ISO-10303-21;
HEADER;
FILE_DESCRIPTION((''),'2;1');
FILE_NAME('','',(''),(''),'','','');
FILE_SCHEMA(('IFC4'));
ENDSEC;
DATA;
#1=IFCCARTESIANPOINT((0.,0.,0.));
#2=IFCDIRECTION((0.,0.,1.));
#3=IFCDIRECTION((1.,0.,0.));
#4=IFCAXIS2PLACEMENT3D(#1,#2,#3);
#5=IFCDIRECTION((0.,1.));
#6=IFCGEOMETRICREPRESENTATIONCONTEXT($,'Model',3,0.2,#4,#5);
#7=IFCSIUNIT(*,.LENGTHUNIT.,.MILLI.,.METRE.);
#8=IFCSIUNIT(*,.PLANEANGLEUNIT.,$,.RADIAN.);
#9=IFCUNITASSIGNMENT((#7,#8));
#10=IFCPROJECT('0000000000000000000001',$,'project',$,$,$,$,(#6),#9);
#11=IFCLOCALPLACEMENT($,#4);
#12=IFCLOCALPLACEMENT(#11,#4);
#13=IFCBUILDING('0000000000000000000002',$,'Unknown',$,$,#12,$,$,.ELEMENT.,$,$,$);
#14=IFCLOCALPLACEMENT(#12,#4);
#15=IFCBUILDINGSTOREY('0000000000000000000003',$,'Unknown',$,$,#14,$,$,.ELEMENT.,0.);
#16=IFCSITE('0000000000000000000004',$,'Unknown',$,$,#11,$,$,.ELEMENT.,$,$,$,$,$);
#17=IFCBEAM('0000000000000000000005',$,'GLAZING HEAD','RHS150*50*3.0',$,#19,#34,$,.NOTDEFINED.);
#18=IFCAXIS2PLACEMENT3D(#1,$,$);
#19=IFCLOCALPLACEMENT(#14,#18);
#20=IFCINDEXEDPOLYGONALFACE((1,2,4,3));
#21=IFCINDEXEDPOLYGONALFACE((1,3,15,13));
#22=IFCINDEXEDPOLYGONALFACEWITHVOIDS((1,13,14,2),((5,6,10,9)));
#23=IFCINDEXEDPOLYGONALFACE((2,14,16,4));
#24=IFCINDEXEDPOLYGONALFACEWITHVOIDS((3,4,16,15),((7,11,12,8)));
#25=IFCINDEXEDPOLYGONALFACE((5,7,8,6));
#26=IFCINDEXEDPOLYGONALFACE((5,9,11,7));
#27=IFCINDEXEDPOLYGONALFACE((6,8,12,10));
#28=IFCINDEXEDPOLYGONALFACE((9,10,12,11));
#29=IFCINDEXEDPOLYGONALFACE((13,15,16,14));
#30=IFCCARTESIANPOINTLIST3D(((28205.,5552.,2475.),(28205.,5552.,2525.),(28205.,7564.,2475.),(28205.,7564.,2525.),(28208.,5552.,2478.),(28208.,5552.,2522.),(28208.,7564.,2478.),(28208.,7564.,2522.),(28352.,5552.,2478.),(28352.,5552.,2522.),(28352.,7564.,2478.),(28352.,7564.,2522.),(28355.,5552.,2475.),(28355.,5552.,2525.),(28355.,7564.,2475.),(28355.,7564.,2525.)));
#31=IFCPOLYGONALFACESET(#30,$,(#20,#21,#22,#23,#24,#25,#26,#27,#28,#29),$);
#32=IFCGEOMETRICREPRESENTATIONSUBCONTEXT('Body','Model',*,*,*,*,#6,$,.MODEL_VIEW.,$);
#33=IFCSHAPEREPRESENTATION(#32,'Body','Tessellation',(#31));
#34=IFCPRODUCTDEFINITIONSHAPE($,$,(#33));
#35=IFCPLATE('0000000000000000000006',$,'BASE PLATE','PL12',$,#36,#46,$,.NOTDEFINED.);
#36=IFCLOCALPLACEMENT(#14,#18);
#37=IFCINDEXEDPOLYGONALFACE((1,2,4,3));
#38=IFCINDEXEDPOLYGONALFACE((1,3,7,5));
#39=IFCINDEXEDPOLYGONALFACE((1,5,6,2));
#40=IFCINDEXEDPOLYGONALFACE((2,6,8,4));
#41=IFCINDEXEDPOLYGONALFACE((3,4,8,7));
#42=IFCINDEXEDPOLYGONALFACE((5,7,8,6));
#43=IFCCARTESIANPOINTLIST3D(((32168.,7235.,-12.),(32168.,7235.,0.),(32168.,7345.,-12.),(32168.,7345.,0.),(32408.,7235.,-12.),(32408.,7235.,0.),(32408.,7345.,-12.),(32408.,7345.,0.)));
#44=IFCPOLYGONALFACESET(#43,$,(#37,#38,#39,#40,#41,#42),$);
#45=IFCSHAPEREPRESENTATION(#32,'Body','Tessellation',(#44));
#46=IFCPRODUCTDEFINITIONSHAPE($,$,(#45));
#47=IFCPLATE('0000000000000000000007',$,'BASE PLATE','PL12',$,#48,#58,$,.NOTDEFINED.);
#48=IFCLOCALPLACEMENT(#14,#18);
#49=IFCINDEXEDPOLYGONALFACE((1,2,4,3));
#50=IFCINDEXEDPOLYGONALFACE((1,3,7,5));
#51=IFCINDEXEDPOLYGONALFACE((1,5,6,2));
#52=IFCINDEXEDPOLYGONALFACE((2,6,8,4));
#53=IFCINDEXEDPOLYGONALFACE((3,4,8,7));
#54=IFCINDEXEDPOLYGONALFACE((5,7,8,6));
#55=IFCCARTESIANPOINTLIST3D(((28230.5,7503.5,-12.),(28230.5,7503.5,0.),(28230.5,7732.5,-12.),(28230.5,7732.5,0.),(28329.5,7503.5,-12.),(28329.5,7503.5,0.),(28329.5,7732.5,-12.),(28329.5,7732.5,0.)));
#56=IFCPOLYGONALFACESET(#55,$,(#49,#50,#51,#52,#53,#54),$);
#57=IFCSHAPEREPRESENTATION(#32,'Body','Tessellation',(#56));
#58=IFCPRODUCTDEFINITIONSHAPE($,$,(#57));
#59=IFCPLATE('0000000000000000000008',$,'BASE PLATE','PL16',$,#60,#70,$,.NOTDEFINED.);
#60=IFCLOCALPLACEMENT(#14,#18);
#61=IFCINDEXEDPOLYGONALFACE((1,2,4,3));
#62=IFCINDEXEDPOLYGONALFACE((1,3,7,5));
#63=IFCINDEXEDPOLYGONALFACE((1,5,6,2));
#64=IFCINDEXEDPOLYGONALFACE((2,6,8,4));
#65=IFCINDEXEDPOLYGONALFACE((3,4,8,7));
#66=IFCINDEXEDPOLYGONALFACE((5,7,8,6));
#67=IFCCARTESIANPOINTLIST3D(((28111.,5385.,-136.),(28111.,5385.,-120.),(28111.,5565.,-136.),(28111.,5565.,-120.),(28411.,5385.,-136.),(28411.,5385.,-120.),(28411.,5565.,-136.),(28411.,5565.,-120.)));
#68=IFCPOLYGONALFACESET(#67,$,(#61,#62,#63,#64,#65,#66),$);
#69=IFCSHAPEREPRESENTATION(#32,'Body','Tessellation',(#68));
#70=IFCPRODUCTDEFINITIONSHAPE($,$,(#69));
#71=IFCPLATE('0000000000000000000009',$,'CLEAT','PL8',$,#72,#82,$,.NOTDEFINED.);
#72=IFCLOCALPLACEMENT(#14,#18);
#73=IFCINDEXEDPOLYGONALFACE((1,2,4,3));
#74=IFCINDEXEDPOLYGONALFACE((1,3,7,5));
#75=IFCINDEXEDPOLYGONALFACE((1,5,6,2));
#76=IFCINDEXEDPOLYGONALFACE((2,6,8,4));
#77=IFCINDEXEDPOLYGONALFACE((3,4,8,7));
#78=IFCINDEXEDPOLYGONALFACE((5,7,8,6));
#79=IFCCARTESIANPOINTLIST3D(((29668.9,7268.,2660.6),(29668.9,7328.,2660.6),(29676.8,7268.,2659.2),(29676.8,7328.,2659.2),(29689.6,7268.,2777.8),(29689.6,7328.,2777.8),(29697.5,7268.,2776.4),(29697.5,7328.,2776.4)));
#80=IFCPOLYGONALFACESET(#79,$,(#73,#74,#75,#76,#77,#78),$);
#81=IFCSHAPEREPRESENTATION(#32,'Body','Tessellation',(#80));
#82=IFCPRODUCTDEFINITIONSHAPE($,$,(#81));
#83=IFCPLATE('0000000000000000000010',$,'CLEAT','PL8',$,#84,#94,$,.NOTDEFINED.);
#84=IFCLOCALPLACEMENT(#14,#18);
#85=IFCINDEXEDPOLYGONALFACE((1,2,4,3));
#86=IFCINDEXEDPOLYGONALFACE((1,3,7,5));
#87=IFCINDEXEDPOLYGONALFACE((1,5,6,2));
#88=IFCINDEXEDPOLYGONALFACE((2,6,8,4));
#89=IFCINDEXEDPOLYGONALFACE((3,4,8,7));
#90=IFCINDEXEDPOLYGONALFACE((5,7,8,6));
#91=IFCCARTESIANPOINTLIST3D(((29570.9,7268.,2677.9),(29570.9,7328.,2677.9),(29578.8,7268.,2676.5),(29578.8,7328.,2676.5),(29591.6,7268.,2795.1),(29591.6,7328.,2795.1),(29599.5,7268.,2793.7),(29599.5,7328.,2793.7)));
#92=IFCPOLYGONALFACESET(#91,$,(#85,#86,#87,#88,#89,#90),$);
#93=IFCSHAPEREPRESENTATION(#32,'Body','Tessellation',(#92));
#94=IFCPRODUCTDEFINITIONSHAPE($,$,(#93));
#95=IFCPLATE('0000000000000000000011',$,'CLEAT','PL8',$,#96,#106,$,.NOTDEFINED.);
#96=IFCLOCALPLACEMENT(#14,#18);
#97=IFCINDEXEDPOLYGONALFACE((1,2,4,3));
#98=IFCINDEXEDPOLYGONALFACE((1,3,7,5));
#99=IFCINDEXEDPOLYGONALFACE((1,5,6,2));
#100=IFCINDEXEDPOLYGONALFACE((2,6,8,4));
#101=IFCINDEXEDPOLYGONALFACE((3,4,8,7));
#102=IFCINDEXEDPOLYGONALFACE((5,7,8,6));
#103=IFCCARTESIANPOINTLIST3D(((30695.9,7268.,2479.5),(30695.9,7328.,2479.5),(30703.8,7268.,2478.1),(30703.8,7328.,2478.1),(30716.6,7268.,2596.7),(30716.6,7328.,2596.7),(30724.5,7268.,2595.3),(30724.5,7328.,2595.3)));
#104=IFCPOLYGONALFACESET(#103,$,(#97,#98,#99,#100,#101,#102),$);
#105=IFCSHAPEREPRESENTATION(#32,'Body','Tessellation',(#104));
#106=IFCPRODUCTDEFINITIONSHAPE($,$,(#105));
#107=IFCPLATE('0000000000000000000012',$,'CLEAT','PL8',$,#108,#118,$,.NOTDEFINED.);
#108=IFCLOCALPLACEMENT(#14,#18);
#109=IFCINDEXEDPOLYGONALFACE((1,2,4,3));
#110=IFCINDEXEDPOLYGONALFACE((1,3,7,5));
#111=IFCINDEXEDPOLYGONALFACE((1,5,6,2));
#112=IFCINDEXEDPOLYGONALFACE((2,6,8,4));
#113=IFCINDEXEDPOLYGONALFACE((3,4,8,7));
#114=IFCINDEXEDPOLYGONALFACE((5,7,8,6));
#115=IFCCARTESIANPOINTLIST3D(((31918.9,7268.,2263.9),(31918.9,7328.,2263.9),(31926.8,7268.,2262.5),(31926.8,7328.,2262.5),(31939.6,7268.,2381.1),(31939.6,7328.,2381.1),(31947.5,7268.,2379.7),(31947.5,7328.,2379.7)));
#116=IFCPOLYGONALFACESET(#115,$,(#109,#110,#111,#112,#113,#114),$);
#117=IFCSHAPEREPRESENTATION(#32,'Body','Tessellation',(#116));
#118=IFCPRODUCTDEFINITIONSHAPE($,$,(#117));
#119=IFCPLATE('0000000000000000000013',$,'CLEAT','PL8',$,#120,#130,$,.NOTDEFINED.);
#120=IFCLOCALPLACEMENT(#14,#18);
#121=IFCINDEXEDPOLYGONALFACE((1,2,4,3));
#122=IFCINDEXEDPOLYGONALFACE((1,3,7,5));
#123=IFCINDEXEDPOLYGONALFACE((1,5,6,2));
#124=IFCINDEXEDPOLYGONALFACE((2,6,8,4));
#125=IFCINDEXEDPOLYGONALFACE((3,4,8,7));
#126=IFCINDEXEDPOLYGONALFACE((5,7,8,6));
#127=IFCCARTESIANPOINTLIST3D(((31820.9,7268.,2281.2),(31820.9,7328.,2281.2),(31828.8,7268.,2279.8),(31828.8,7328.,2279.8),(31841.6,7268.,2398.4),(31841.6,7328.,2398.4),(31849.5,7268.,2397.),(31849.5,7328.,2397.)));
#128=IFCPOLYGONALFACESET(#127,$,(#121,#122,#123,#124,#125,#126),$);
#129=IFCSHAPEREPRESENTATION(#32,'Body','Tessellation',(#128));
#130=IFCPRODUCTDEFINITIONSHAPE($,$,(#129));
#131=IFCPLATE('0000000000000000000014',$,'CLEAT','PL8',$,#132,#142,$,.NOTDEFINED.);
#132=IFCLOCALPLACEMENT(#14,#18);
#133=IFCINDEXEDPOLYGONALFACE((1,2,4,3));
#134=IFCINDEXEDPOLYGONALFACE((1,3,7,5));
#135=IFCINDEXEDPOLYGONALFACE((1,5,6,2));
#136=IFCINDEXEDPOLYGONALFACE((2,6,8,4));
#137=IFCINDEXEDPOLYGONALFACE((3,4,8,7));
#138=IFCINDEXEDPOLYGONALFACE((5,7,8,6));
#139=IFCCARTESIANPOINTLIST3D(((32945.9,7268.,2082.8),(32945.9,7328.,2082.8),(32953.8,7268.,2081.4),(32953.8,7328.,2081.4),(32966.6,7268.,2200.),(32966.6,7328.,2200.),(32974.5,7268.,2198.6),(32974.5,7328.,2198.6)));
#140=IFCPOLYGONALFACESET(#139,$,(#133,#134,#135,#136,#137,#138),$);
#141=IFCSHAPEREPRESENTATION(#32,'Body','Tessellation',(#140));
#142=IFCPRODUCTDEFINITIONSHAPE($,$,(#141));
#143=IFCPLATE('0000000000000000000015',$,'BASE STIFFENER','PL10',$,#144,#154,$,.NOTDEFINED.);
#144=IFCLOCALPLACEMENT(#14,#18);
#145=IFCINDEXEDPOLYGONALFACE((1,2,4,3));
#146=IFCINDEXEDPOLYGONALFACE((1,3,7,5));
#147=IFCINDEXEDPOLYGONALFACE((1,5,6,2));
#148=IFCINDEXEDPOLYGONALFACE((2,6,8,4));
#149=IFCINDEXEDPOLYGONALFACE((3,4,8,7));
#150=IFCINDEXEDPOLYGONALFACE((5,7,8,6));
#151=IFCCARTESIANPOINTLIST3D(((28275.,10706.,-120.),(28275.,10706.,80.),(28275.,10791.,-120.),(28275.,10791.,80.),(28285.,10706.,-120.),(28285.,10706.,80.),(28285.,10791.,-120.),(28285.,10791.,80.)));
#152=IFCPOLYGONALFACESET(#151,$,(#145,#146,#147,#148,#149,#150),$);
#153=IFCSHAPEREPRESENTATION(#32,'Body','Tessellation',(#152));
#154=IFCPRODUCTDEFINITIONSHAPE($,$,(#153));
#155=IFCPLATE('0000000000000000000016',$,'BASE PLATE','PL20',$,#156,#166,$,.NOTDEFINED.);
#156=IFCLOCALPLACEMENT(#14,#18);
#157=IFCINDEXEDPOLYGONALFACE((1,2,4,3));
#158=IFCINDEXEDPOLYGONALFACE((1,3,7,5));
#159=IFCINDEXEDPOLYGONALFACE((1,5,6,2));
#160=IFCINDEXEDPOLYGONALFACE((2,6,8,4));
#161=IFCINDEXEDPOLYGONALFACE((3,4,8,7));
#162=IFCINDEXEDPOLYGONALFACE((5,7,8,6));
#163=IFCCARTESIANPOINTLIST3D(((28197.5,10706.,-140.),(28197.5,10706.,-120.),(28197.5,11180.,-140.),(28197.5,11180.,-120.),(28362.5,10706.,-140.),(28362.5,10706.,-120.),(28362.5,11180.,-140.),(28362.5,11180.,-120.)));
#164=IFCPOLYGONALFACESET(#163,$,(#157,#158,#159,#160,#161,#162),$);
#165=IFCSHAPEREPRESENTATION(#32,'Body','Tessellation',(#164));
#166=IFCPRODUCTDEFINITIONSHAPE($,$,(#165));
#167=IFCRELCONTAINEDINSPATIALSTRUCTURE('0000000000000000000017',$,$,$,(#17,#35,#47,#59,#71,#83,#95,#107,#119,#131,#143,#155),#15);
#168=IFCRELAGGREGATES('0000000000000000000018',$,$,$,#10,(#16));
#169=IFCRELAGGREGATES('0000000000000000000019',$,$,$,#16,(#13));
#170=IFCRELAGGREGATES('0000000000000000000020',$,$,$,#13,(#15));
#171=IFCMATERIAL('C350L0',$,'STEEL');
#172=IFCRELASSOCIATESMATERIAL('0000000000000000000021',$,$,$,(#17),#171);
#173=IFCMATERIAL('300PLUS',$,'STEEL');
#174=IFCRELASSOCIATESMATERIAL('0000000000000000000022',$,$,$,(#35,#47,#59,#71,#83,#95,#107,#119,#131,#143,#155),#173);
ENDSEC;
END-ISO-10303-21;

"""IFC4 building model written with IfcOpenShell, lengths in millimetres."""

from ifc_helpers import new_model, si_unit, direction, frame, origin_with_axes, place, context, subcontext, project, spatial, line, indexed_curve, outline, extrude, material, element, save


model = new_model("IFC4")

# Units and contexts
model_context = context("Model", 3, precision=0.2, world=origin_with_axes(), true_north=direction((0.0, 1.0)))
body_context = subcontext(model_context, "Body", "Model", "MODEL_VIEW")
ifc_project = project(units=[si_unit("LENGTHUNIT", "METRE", prefix="MILLI"), si_unit("PLANEANGLEUNIT", "RADIAN")], contexts=[model_context])

# Site, building, storey
site_placement = place(None, origin_with_axes())
site = spatial("IfcSite", under=ifc_project, at=site_placement, Name="Unknown", CompositionType="ELEMENT")
building_placement = place(site_placement, origin_with_axes())
building = spatial("IfcBuilding", under=site, at=building_placement, Name="Unknown", CompositionType="ELEMENT")
storey_placement = place(building_placement, origin_with_axes())
storey = spatial("IfcBuildingStorey", under=building, at=storey_placement, Name="Unknown", CompositionType="ELEMENT", Elevation=0.0)

# Shared definitions
ifc_material_1 = material(Name="C350L0", Category="STEEL")
ifc_material_2 = material(Name="300PLUS", Category="STEEL")

# Beam
beam_1_placement = place(storey_placement, frame((28280.0, 5552.0, 2500.0), z_axis=(0.0, 0.0, 1.0), x_axis=(0.0, 1.0, 0.0)))
element("IfcBeam", 1, at=beam_1_placement, inside=storey, material=ifc_material_1, Name="GLAZING HEAD", Description="RHS150*50*3.0", PredefinedType="NOTDEFINED", context=body_context, shape_type="SolidModel", body=[
    extrude(outline(indexed_curve([(-25.0, -75.0), (25.0, -75.0), (25.0, 75.0), (-25.0, 75.0)], segments=[line(1, 2, 3, 4, 1)]), holes=[indexed_curve([(-22.0, -72.0), (-22.0, 72.0), (22.0, 72.0), (22.0, -72.0)], segments=[line(1, 2, 3, 4, 1)])]), frame((0.0, 0.0, 0.0), z_axis=(-1.0, 0.0, 0.0), x_axis=(0.0, 0.0, 1.0)), (0.0, 0.0, -1.0), 2012.0),
])

# Plates
plate_1_placement = place(storey_placement, frame((32168.0, 7235.0, -6.0), z_axis=(0.0, 0.0, 1.0), x_axis=(1.0, 0.0, 0.0)))
element("IfcPlate", 2, at=plate_1_placement, inside=storey, material=ifc_material_2, Name="BASE PLATE", Description="PL12", PredefinedType="NOTDEFINED", context=body_context, shape_type="SolidModel", body=[
    extrude(outline(indexed_curve([(0.0, 0.0), (240.0, 0.0), (240.0, 110.0), (0.0, 110.0)], segments=[line(1, 2, 3, 4, 1)])), frame((0.0, 0.0, 6.0), z_axis=(0.0, 0.0, 1.0), x_axis=(1.0, 0.0, 0.0)), (0.0, 0.0, -1.0), 12.0),
])
plate_2_placement = place(storey_placement, frame((28230.5, 7503.5, -6.0), z_axis=(0.0, 0.0, 1.0), x_axis=(1.0, 0.0, 0.0)))
element("IfcPlate", 3, at=plate_2_placement, inside=storey, material=ifc_material_2, Name="BASE PLATE", Description="PL12", PredefinedType="NOTDEFINED", context=body_context, shape_type="SolidModel", body=[
    extrude(outline(indexed_curve([(0.0, 0.0), (99.0, 0.0), (99.0, 229.0), (0.0, 229.0)], segments=[line(1, 2, 3, 4, 1)])), frame((0.0, 0.0, 6.0), z_axis=(0.0, 0.0, 1.0), x_axis=(1.0, 0.0, 0.0)), (0.0, 0.0, -1.0), 12.0),
])
plate_3_placement = place(storey_placement, frame((28111.0, 5385.0, -128.0), z_axis=(0.0, 0.0, 1.0), x_axis=(1.0, 0.0, 0.0)))
element("IfcPlate", 4, at=plate_3_placement, inside=storey, material=ifc_material_2, Name="BASE PLATE", Description="PL16", PredefinedType="NOTDEFINED", context=body_context, shape_type="SolidModel", body=[
    extrude(outline(indexed_curve([(0.0, 0.0), (300.0, 0.0), (300.0, 180.0), (0.0, 180.0)], segments=[line(1, 2, 3, 4, 1)])), frame((0.0, 0.0, 8.0), z_axis=(0.0, 0.0, 1.0), x_axis=(1.0, 0.0, 0.0)), (0.0, 0.0, -1.0), 16.0),
])
for number, where, z_axis, x_axis, name in (
    (5, (29672.9, 7328.0, 2659.9), (-0.984758, 0.0, 0.173929), (0.0, -1.0, 0.0), "CLEAT"),
    (6, (29574.9, 7328.0, 2677.2), (-0.984758, 0.0, 0.173929), (0.0, -1.0, 0.0), "CLEAT"),
    (7, (30699.9, 7328.0, 2478.8), (-0.984758, 0.0, 0.173929), (0.0, -1.0, 0.0), "CLEAT"),
    (8, (31922.9, 7328.0, 2263.2), (-0.984758, 0.0, 0.173929), (0.0, -1.0, 0.0), "CLEAT"),
    (9, (31824.9, 7328.0, 2280.5), (-0.984758, 0.0, 0.173929), (0.0, -1.0, 0.0), "CLEAT"),
    (10, (32949.9, 7328.0, 2082.1), (-0.984758, 0.0, 0.173929), (0.0, -1.0, 0.0), "CLEAT"),
):
    element("IfcPlate", number, at=place(storey_placement, frame(where, z_axis=z_axis, x_axis=x_axis)), inside=storey, material=ifc_material_2, Name=name, Description="PL8", PredefinedType="NOTDEFINED", context=body_context, shape_type="SolidModel", body=[
        extrude(outline(indexed_curve([(0.0, 0.0), (60.0, 0.0), (60.0, 119.0), (0.0, 119.0)], segments=[line(1, 2, 3, 4, 1)])), frame((0.0, 0.0, 4.0), z_axis=(0.0, 0.0, 1.0), x_axis=(1.0, 0.0, 0.0)), (0.0, 0.0, -1.0), 8.0),
    ])
plate_4_placement = place(storey_placement, frame((28280.0, 10706.0, -120.0), z_axis=(1.0, 0.0, 0.0), x_axis=(0.0, 1.0, 0.0)))
element("IfcPlate", 11, at=plate_4_placement, inside=storey, material=ifc_material_2, Name="BASE STIFFENER", Description="PL10", PredefinedType="NOTDEFINED", context=body_context, shape_type="SolidModel", body=[
    extrude(outline(indexed_curve([(0.0, 0.0), (85.0, 0.0), (85.0, 200.0), (0.0, 200.0)], segments=[line(1, 2, 3, 4, 1)])), frame((0.0, 0.0, 5.0), z_axis=(0.0, 0.0, 1.0), x_axis=(1.0, 0.0, 0.0)), (0.0, 0.0, -1.0), 10.0),
])
plate_5_placement = place(storey_placement, frame((28197.5, 10706.0, -130.0), z_axis=(0.0, 0.0, 1.0), x_axis=(1.0, 0.0, 0.0)))
element("IfcPlate", 12, at=plate_5_placement, inside=storey, material=ifc_material_2, Name="BASE PLATE", Description="PL20", PredefinedType="NOTDEFINED", context=body_context, shape_type="SolidModel", body=[
    extrude(outline(indexed_curve([(0.0, 0.0), (165.0, 0.0), (165.0, 474.0), (0.0, 474.0)], segments=[line(1, 2, 3, 4, 1)])), frame((0.0, 0.0, 10.0), z_axis=(0.0, 0.0, 1.0), x_axis=(1.0, 0.0, 0.0)), (0.0, 0.0, -1.0), 20.0),
])

save(model, "model.ifc")
